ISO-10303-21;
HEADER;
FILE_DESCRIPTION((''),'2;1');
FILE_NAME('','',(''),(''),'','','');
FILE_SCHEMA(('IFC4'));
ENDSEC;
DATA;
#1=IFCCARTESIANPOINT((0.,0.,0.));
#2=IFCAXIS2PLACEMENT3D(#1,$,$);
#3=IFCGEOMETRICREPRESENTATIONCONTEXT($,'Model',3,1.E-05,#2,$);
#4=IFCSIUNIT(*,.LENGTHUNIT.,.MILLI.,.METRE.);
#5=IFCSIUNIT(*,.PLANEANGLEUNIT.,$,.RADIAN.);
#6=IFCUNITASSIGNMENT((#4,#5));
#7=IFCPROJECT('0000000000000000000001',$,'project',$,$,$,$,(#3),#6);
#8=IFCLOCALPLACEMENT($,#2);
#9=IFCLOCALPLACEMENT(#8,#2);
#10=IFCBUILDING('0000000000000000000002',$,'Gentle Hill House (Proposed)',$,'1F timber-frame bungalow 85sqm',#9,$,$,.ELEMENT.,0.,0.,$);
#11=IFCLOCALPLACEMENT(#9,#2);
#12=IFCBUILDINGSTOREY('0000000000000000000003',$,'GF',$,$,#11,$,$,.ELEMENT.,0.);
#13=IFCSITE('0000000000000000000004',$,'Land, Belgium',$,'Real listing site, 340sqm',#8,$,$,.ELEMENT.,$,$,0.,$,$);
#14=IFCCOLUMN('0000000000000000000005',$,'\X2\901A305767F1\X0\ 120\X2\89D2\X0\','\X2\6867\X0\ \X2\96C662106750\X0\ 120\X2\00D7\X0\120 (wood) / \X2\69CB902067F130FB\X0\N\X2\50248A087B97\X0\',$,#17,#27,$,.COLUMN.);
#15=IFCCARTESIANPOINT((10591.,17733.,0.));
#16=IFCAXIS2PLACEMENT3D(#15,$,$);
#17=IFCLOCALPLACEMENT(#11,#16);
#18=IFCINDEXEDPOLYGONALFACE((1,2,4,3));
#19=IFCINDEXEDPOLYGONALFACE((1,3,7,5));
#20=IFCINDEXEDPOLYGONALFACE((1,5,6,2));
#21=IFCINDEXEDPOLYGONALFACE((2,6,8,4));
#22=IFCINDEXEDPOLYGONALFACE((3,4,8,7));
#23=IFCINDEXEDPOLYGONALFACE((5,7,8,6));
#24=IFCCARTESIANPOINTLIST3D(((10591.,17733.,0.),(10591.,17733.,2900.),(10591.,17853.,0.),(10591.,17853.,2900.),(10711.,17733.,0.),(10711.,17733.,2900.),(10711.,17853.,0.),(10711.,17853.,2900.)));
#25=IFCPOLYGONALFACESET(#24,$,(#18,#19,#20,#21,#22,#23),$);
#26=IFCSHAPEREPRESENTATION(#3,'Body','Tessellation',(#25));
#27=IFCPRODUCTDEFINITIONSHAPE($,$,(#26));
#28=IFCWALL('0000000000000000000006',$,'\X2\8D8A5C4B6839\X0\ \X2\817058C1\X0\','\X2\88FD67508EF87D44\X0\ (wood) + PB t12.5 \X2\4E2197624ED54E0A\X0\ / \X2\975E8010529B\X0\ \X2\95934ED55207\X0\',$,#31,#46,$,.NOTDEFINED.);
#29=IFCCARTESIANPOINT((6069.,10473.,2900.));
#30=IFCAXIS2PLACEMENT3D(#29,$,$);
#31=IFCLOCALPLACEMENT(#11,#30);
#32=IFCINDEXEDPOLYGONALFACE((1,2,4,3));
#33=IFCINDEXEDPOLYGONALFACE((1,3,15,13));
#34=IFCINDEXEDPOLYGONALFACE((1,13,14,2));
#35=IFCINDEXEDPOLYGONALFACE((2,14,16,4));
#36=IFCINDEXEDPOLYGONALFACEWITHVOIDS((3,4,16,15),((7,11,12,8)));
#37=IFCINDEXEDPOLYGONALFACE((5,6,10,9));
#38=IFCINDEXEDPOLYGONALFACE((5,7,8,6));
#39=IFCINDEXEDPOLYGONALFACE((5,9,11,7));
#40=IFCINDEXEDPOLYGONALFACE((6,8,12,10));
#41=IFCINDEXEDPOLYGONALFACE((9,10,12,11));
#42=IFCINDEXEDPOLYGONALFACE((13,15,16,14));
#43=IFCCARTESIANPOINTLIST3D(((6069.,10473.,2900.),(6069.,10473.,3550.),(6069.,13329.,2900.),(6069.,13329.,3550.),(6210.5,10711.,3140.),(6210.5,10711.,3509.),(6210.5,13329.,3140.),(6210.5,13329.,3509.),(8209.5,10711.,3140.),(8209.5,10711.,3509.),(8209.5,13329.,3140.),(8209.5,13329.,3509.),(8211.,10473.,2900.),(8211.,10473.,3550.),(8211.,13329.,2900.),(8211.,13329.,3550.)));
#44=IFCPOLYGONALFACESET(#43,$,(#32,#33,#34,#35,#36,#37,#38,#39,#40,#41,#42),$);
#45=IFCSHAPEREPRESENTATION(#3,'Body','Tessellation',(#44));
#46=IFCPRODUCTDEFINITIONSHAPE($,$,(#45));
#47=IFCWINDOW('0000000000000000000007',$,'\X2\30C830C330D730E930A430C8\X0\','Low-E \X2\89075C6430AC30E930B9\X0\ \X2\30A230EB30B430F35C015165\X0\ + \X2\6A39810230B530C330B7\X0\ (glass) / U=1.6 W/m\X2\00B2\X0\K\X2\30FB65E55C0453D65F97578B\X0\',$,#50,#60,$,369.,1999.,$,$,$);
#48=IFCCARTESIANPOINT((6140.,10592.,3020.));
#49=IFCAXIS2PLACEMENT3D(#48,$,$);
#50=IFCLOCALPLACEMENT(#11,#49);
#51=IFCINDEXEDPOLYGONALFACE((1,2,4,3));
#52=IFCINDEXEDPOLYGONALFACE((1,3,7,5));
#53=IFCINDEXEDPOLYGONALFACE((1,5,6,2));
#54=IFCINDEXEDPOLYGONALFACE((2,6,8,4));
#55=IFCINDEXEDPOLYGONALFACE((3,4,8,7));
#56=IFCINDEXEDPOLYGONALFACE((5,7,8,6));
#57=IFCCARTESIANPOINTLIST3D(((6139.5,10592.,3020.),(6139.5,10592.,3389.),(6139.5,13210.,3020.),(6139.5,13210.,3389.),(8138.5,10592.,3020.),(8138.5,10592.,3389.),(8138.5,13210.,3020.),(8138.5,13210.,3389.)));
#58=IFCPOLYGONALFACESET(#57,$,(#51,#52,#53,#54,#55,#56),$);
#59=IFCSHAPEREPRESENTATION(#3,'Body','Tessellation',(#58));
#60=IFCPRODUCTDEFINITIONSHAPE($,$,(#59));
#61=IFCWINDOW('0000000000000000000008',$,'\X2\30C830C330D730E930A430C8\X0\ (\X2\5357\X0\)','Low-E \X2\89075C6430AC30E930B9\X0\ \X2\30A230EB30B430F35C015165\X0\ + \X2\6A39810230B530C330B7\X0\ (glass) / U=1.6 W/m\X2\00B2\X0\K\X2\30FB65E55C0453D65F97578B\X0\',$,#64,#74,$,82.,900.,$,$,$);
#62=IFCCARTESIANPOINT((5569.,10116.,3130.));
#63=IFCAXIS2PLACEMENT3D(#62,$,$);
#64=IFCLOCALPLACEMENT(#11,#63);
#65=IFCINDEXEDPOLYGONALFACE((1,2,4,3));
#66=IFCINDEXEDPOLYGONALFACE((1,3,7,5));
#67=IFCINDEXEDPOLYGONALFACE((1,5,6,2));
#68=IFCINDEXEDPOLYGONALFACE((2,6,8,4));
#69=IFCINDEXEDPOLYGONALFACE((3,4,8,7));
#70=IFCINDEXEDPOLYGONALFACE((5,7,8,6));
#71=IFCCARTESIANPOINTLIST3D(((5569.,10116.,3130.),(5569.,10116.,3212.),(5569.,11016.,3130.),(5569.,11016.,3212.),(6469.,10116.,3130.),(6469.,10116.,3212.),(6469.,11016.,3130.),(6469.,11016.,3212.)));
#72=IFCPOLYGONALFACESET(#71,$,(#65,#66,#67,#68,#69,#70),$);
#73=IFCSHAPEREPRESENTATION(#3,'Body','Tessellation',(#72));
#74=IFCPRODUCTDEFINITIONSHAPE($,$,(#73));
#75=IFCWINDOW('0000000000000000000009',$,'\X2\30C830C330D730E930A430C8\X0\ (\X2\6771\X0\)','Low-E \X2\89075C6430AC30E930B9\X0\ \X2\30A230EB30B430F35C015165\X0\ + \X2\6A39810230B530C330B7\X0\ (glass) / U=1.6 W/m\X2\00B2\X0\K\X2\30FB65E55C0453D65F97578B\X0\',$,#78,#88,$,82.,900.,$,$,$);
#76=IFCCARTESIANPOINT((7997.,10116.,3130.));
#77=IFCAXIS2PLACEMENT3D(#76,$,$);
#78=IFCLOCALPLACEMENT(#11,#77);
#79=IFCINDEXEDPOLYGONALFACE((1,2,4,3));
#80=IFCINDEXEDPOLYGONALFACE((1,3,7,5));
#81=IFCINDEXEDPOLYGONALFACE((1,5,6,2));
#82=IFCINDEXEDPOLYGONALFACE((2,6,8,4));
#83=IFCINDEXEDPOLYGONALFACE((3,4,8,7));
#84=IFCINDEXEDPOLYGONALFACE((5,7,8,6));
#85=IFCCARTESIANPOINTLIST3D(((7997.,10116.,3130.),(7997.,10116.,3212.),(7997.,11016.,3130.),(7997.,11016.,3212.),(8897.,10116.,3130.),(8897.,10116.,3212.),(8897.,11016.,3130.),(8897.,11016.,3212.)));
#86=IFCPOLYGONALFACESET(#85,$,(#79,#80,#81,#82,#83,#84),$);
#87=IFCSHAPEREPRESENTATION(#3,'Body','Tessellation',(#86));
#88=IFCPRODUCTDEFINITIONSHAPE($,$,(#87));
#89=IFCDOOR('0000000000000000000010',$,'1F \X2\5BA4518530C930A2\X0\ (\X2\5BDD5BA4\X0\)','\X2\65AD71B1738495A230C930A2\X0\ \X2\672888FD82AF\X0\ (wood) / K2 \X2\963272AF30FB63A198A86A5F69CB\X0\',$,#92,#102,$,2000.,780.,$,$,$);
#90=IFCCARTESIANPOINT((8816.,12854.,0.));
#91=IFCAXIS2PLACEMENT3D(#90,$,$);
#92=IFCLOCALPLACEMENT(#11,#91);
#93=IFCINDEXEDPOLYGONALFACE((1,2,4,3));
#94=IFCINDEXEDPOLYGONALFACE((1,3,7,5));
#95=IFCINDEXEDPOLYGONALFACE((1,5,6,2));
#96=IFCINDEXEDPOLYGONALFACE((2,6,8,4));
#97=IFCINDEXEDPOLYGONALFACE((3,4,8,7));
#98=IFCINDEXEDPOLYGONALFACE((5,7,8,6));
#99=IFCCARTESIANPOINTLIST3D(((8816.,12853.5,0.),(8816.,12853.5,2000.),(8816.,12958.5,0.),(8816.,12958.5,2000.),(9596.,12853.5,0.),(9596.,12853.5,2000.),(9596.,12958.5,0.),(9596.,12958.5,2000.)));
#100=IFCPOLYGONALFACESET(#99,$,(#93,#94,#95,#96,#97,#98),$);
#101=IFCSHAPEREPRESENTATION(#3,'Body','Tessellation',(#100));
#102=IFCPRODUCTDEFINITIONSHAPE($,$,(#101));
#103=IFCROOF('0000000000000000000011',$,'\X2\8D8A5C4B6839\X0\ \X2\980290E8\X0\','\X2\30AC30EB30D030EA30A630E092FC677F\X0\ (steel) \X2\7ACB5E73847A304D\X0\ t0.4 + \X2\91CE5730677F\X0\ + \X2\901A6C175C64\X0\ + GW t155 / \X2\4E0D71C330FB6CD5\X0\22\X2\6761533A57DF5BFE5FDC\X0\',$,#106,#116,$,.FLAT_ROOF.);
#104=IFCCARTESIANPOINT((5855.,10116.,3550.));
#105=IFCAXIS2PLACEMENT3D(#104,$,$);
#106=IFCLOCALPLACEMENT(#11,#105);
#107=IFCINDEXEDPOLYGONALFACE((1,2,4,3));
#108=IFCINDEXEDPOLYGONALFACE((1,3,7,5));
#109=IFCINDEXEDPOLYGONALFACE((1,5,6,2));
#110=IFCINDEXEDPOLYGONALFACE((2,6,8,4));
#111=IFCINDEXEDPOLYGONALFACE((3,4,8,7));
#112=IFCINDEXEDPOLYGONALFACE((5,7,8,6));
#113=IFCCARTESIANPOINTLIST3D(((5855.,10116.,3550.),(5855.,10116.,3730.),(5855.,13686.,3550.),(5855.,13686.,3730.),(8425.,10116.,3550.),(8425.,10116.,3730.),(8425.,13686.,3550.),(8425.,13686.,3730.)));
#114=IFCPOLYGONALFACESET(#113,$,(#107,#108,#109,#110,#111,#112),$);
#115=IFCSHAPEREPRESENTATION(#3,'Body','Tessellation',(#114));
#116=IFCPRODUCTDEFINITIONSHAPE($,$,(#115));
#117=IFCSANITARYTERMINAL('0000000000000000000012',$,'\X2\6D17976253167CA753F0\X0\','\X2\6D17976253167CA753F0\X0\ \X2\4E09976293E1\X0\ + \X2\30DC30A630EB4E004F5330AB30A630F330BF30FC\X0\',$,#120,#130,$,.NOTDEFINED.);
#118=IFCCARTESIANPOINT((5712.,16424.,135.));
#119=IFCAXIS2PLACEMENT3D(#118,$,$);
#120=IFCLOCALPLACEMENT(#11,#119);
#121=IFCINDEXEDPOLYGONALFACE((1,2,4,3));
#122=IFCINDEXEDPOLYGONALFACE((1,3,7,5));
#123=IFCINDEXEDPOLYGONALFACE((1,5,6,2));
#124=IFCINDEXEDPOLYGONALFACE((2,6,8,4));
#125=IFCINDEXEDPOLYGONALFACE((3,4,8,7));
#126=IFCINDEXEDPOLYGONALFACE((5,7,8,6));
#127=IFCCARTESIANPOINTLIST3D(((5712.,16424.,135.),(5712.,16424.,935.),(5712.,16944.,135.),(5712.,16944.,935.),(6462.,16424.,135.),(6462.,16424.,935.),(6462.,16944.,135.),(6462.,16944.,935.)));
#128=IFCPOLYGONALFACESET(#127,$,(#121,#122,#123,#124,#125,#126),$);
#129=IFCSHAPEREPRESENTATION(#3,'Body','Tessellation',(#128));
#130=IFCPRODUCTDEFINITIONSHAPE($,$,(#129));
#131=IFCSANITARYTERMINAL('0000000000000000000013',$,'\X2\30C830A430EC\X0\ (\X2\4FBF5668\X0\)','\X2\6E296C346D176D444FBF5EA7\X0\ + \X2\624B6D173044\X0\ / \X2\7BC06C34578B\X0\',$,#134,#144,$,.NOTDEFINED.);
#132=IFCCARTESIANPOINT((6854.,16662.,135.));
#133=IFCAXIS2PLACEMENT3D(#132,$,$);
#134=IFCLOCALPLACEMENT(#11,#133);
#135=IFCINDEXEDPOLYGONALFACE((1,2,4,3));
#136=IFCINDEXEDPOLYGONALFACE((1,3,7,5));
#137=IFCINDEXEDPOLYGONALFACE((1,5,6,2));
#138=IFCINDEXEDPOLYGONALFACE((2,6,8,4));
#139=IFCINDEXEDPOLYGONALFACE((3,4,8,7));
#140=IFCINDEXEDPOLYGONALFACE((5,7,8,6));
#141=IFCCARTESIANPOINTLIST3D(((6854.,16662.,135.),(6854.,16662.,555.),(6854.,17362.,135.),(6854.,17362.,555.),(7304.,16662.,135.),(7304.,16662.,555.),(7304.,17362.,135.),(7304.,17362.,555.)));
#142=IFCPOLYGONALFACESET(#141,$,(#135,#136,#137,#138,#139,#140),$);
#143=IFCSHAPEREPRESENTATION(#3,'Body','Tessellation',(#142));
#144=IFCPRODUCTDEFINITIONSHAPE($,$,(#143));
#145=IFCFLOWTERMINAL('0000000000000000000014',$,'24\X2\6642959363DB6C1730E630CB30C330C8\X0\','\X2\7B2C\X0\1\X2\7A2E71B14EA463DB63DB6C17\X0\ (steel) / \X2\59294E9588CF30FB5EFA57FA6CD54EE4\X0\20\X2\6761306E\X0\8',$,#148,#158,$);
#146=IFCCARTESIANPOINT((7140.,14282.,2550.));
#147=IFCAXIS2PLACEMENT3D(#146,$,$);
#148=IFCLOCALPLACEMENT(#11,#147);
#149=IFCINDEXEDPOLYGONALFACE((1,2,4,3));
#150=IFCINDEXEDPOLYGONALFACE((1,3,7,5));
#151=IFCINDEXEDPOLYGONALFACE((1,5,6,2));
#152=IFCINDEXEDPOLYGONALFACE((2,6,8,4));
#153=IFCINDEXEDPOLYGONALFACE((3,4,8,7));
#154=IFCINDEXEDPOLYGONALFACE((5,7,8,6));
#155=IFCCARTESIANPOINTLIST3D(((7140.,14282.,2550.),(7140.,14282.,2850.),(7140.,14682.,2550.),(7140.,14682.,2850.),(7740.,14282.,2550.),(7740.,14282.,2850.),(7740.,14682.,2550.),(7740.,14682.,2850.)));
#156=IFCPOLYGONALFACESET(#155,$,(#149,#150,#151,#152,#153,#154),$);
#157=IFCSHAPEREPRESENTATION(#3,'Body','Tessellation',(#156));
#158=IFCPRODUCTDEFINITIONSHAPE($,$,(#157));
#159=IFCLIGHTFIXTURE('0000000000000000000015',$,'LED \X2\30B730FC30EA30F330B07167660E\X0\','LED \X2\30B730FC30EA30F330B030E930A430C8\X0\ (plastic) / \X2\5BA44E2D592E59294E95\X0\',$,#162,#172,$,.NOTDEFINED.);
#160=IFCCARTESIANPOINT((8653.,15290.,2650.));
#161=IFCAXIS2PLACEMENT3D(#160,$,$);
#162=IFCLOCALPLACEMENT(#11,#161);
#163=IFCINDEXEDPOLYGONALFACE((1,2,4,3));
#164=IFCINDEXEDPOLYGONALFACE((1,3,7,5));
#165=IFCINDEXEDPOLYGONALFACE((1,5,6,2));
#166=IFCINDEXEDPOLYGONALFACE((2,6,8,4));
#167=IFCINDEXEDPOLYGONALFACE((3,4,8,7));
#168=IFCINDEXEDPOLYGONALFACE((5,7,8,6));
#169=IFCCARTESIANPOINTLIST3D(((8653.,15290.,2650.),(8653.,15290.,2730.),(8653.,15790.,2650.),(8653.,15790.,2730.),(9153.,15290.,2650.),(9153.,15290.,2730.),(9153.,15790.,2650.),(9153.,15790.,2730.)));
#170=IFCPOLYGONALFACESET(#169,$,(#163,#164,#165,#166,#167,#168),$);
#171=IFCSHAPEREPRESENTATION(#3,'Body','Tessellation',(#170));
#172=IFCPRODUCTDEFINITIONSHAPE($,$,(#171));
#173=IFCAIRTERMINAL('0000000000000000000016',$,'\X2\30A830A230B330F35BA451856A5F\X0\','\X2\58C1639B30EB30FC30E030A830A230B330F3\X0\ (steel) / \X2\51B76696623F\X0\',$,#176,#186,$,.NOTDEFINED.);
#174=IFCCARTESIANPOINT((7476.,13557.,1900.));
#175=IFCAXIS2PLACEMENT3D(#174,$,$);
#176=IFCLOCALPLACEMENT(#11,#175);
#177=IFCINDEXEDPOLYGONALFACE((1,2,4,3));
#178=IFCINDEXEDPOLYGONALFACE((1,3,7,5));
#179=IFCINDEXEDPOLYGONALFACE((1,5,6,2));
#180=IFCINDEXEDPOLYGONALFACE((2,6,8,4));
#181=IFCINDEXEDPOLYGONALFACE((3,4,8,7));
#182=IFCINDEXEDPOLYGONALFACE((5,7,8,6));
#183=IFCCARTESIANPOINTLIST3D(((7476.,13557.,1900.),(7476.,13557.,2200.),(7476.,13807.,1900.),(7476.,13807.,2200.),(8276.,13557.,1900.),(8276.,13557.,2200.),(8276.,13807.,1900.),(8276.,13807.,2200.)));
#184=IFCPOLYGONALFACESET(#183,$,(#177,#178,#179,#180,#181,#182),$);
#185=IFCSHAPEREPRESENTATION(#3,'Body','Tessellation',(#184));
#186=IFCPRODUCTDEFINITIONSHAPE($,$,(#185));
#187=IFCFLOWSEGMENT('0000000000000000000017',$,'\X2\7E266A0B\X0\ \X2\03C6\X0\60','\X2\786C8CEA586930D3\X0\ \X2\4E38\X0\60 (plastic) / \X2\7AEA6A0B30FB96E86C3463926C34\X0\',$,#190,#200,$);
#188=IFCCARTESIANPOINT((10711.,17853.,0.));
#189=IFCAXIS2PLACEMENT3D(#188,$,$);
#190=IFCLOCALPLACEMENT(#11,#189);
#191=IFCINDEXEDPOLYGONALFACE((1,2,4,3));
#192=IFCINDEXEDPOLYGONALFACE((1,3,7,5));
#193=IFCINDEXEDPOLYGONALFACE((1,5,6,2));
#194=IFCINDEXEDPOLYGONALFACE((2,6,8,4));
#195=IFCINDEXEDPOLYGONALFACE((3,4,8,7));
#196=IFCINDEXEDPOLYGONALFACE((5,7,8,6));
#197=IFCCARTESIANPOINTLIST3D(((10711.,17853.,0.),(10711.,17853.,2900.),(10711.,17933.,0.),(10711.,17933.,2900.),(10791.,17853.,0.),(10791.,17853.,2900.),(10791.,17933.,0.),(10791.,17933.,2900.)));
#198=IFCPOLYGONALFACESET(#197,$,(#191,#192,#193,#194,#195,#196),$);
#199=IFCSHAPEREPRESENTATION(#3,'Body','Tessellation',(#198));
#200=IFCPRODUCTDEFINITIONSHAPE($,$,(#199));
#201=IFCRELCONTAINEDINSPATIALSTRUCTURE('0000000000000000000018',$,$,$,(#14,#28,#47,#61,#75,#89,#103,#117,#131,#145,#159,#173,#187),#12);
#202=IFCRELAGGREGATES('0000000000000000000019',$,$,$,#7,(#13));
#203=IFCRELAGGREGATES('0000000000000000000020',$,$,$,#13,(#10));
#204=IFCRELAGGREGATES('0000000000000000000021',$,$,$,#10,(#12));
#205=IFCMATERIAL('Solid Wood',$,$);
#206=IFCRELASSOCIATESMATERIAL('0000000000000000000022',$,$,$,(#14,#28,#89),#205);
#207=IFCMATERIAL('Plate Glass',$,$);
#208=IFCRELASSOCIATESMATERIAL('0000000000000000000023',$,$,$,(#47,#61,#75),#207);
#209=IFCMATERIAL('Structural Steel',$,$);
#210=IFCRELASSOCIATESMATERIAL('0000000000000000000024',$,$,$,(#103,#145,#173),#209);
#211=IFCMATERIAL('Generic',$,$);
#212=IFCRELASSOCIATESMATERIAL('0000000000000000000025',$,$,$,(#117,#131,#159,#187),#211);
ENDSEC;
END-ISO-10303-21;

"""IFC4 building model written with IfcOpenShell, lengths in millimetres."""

from ifc_helpers import new_model, si_unit, frame, frame_2d, origin, place, context, project, spatial, rectangle, extrude, material, element, fill, save


model = new_model("IFC4")

# Units and contexts
model_context = context("Model", 3, precision=1e-05, world=origin())
ifc_project = project(units=[si_unit("LENGTHUNIT", "METRE", prefix="MILLI"), si_unit("PLANEANGLEUNIT", "RADIAN")], contexts=[model_context])

# Site, building, storey
site_placement = place(None, origin())
site = spatial("IfcSite", under=ifc_project, at=site_placement, Name="Land, Belgium", ObjectType="Real listing site, 340sqm", CompositionType="ELEMENT", RefElevation=0.0)
building_placement = place(site_placement, origin())
building = spatial("IfcBuilding", under=site, at=building_placement, Name="Gentle Hill House (Proposed)", ObjectType="1F timber-frame bungalow 85sqm", CompositionType="ELEMENT", ElevationOfRefHeight=0.0, ElevationOfTerrain=0.0)
storey_placement = place(building_placement, origin())
storey = spatial("IfcBuildingStorey", under=building, at=storey_placement, Name="GF", CompositionType="ELEMENT", Elevation=0.0)

# Column
ifc_material_1 = material(Name="Solid Wood")
column_1_placement = place(storey_placement, frame((10591.0, 17733.0, 0.0)))
element("IfcColumn", 1, at=column_1_placement, inside=storey, material=ifc_material_1, Name="通し柱 120角", Description="桧 集成材 120×120 (wood) / 構造柱・N値計算", PredefinedType="COLUMN", context=model_context, shape_type="SweptSolid", body=[
    extrude(rectangle(XDim=120.0, YDim=120.0, at=frame_2d((60.0, 60.0))), frame((10591.0, 17733.0, 0.0)), (0.0, 0.0, 1.0), 2900.0),
])

# Wall, openings, windows
wall_1_placement = place(storey_placement, frame((6069.0, 10473.0, 2900.0)))
wall_1 = element("IfcWall", 2, at=wall_1_placement, inside=storey, material=ifc_material_1, Name="越屋根 腰壁", Description="製材軸組 (wood) + PB t12.5 両面仕上 / 非耐力 間仕切", PredefinedType="NOTDEFINED", context=model_context, shape_type="SweptSolid", body=[
    extrude(rectangle(XDim=2142.0, YDim=2856.0, at=frame_2d((1071.0, 1428.0))), frame((6069.0, 10473.0, 2900.0)), (0.0, 0.0, 1.0), 650.0),
])
opening_1_placement = place(storey_placement, frame((6140.0, 10592.0, 3020.0)))
opening_1 = element("IfcOpeningElement", 3, at=opening_1_placement, cuts=wall_1, PredefinedType="NOTDEFINED", context=model_context, shape_type="SweptSolid", body=[
    extrude(rectangle(XDim=1999.0, YDim=2618.0, at=frame_2d((999.0, 1309.0))), frame((6140.0, 10592.0, 3020.0)), (0.0, 0.0, 1.0), 369.0),
])
opening_2_placement = place(storey_placement, frame((5569.0, 10116.0, 3130.0)))
opening_2 = element("IfcOpeningElement", 4, at=opening_2_placement, cuts=wall_1, PredefinedType="NOTDEFINED", context=model_context, shape_type="SweptSolid", body=[
    extrude(rectangle(XDim=900.0, YDim=900.0, at=frame_2d((450.0, 450.0))), frame((5569.0, 10116.0, 3130.0)), (0.0, 0.0, 1.0), 82.0),
])
opening_3_placement = place(storey_placement, frame((7997.0, 10116.0, 3130.0)))
opening_3 = element("IfcOpeningElement", 5, at=opening_3_placement, cuts=wall_1, PredefinedType="NOTDEFINED", context=model_context, shape_type="SweptSolid", body=[
    extrude(rectangle(XDim=900.0, YDim=900.0, at=frame_2d((450.0, 450.0))), frame((7997.0, 10116.0, 3130.0)), (0.0, 0.0, 1.0), 82.0),
])
ifc_material_2 = material(Name="Plate Glass")
window_1_placement = place(storey_placement, frame((6140.0, 10592.0, 3020.0)))
window_1 = element("IfcWindow", 6, at=window_1_placement, inside=storey, material=ifc_material_2, Name="トップライト", Description="Low-E 複層ガラス アルゴン封入 + 樹脂サッシ (glass) / U=1.6 W/m²K・日射取得型", OverallHeight=369.0, OverallWidth=1999.0, context=model_context, shape_type="SweptSolid", body=[
    extrude(rectangle(XDim=1999.0, YDim=2618.0, at=frame_2d((999.0, 1309.0))), frame((6140.0, 10592.0, 3020.0)), (0.0, 0.0, 1.0), 369.0),
])
fill(opening_1, window_1)
window_2_placement = place(storey_placement, frame((5569.0, 10116.0, 3130.0)))
window_2 = element("IfcWindow", 7, at=window_2_placement, inside=storey, material=ifc_material_2, Name="トップライト (南)", Description="Low-E 複層ガラス アルゴン封入 + 樹脂サッシ (glass) / U=1.6 W/m²K・日射取得型", OverallHeight=82.0, OverallWidth=900.0, context=model_context, shape_type="SweptSolid", body=[
    extrude(rectangle(XDim=900.0, YDim=900.0, at=frame_2d((450.0, 450.0))), frame((5569.0, 10116.0, 3130.0)), (0.0, 0.0, 1.0), 82.0),
])
fill(opening_2, window_2)
window_3_placement = place(storey_placement, frame((7997.0, 10116.0, 3130.0)))
window_3 = element("IfcWindow", 8, at=window_3_placement, inside=storey, material=ifc_material_2, Name="トップライト (東)", Description="Low-E 複層ガラス アルゴン封入 + 樹脂サッシ (glass) / U=1.6 W/m²K・日射取得型", OverallHeight=82.0, OverallWidth=900.0, context=model_context, shape_type="SweptSolid", body=[
    extrude(rectangle(XDim=900.0, YDim=900.0, at=frame_2d((450.0, 450.0))), frame((7997.0, 10116.0, 3130.0)), (0.0, 0.0, 1.0), 82.0),
])
fill(opening_3, window_3)

# Door
door_placement = place(storey_placement, frame((8816.0, 12854.0, 0.0)))
element("IfcDoor", 9, at=door_placement, inside=storey, material=ifc_material_1, Name="1F 室内ドア (寝室)", Description="断熱玄関ドア 木製芯 (wood) / K2 防犯・採風機構", OverallHeight=2000.0, OverallWidth=780.0, context=model_context, shape_type="SweptSolid", body=[
    extrude(rectangle(XDim=780.0, YDim=105.0, at=frame_2d((390.0, 52.0))), frame((8816.0, 12854.0, 0.0)), (0.0, 0.0, 1.0), 2000.0),
])

# Roof
ifc_material_3 = material(Name="Structural Steel")
roof_placement = place(storey_placement, frame((5855.0, 10116.0, 3550.0)))
element("IfcRoof", 10, at=roof_placement, inside=storey, material=ifc_material_3, Name="越屋根 頂部", Description="ガルバリウム鋼板 (steel) 立平葺き t0.4 + 野地板 + 通気層 + GW t155 / 不燃・法22条区域対応", PredefinedType="FLAT_ROOF", context=model_context, shape_type="SweptSolid", body=[
    extrude(rectangle(XDim=2570.0, YDim=3570.0, at=frame_2d((1285.0, 1785.0))), frame((5855.0, 10116.0, 3550.0)), (0.0, 0.0, 1.0), 180.0),
])

# Sanitary terminals
ifc_material_4 = material(Name="Generic")
sanitary_terminal_1_placement = place(storey_placement, frame((5712.0, 16424.0, 135.0)))
element("IfcSanitaryTerminal", 11, at=sanitary_terminal_1_placement, inside=storey, material=ifc_material_4, Name="洗面化粧台", Description="洗面化粧台 三面鏡 + ボウル一体カウンター", PredefinedType="NOTDEFINED", context=model_context, shape_type="SweptSolid", body=[
    extrude(rectangle(XDim=750.0, YDim=520.0, at=frame_2d((375.0, 260.0))), frame((5712.0, 16424.0, 135.0)), (0.0, 0.0, 1.0), 800.0),
])
sanitary_terminal_2_placement = place(storey_placement, frame((6854.0, 16662.0, 135.0)))
element("IfcSanitaryTerminal", 12, at=sanitary_terminal_2_placement, inside=storey, material=ifc_material_4, Name="トイレ (便器)", Description="温水洗浄便座 + 手洗い / 節水型", PredefinedType="NOTDEFINED", context=model_context, shape_type="SweptSolid", body=[
    extrude(rectangle(XDim=450.0, YDim=700.0, at=frame_2d((225.0, 350.0))), frame((6854.0, 16662.0, 135.0)), (0.0, 0.0, 1.0), 420.0),
])

# Flow terminal
flow_terminal_placement = place(storey_placement, frame((7140.0, 14282.0, 2550.0)))
element("IfcFlowTerminal", 13, at=flow_terminal_placement, inside=storey, material=ifc_material_3, Name="24時間換気ユニット", Description="第1種熱交換換気 (steel) / 天井裏・建基法令20条の8", context=model_context, shape_type="SweptSolid", body=[
    extrude(rectangle(XDim=600.0, YDim=400.0, at=frame_2d((300.0, 200.0))), frame((7140.0, 14282.0, 2550.0)), (0.0, 0.0, 1.0), 300.0),
])

# Light fixture
light_fixture_placement = place(storey_placement, frame((8653.0, 15290.0, 2650.0)))
element("IfcLightFixture", 14, at=light_fixture_placement, inside=storey, material=ifc_material_4, Name="LED シーリング照明", Description="LED シーリングライト (plastic) / 室中央天井", PredefinedType="NOTDEFINED", context=model_context, shape_type="SweptSolid", body=[
    extrude(rectangle(XDim=500.0, YDim=500.0, at=frame_2d((250.0, 250.0))), frame((8653.0, 15290.0, 2650.0)), (0.0, 0.0, 1.0), 80.0),
])

# Air terminal
air_terminal_placement = place(storey_placement, frame((7476.0, 13557.0, 1900.0)))
element("IfcAirTerminal", 15, at=air_terminal_placement, inside=storey, material=ifc_material_3, Name="エアコン室内機", Description="壁掛ルームエアコン (steel) / 冷暖房", PredefinedType="NOTDEFINED", context=model_context, shape_type="SweptSolid", body=[
    extrude(rectangle(XDim=800.0, YDim=250.0, at=frame_2d((400.0, 125.0))), frame((7476.0, 13557.0, 1900.0)), (0.0, 0.0, 1.0), 300.0),
])

# Flow segment
flow_segment_placement = place(storey_placement, frame((10711.0, 17853.0, 0.0)))
element("IfcFlowSegment", 16, at=flow_segment_placement, inside=storey, material=ifc_material_4, Name="縦樋 φ60", Description="硬質塩ビ 丸60 (plastic) / 竪樋・雨水排水", context=model_context, shape_type="SweptSolid", body=[
    extrude(rectangle(XDim=80.0, YDim=80.0, at=frame_2d((40.0, 40.0))), frame((10711.0, 17853.0, 0.0)), (0.0, 0.0, 1.0), 2900.0),
])

save(model, "model.ifc")
